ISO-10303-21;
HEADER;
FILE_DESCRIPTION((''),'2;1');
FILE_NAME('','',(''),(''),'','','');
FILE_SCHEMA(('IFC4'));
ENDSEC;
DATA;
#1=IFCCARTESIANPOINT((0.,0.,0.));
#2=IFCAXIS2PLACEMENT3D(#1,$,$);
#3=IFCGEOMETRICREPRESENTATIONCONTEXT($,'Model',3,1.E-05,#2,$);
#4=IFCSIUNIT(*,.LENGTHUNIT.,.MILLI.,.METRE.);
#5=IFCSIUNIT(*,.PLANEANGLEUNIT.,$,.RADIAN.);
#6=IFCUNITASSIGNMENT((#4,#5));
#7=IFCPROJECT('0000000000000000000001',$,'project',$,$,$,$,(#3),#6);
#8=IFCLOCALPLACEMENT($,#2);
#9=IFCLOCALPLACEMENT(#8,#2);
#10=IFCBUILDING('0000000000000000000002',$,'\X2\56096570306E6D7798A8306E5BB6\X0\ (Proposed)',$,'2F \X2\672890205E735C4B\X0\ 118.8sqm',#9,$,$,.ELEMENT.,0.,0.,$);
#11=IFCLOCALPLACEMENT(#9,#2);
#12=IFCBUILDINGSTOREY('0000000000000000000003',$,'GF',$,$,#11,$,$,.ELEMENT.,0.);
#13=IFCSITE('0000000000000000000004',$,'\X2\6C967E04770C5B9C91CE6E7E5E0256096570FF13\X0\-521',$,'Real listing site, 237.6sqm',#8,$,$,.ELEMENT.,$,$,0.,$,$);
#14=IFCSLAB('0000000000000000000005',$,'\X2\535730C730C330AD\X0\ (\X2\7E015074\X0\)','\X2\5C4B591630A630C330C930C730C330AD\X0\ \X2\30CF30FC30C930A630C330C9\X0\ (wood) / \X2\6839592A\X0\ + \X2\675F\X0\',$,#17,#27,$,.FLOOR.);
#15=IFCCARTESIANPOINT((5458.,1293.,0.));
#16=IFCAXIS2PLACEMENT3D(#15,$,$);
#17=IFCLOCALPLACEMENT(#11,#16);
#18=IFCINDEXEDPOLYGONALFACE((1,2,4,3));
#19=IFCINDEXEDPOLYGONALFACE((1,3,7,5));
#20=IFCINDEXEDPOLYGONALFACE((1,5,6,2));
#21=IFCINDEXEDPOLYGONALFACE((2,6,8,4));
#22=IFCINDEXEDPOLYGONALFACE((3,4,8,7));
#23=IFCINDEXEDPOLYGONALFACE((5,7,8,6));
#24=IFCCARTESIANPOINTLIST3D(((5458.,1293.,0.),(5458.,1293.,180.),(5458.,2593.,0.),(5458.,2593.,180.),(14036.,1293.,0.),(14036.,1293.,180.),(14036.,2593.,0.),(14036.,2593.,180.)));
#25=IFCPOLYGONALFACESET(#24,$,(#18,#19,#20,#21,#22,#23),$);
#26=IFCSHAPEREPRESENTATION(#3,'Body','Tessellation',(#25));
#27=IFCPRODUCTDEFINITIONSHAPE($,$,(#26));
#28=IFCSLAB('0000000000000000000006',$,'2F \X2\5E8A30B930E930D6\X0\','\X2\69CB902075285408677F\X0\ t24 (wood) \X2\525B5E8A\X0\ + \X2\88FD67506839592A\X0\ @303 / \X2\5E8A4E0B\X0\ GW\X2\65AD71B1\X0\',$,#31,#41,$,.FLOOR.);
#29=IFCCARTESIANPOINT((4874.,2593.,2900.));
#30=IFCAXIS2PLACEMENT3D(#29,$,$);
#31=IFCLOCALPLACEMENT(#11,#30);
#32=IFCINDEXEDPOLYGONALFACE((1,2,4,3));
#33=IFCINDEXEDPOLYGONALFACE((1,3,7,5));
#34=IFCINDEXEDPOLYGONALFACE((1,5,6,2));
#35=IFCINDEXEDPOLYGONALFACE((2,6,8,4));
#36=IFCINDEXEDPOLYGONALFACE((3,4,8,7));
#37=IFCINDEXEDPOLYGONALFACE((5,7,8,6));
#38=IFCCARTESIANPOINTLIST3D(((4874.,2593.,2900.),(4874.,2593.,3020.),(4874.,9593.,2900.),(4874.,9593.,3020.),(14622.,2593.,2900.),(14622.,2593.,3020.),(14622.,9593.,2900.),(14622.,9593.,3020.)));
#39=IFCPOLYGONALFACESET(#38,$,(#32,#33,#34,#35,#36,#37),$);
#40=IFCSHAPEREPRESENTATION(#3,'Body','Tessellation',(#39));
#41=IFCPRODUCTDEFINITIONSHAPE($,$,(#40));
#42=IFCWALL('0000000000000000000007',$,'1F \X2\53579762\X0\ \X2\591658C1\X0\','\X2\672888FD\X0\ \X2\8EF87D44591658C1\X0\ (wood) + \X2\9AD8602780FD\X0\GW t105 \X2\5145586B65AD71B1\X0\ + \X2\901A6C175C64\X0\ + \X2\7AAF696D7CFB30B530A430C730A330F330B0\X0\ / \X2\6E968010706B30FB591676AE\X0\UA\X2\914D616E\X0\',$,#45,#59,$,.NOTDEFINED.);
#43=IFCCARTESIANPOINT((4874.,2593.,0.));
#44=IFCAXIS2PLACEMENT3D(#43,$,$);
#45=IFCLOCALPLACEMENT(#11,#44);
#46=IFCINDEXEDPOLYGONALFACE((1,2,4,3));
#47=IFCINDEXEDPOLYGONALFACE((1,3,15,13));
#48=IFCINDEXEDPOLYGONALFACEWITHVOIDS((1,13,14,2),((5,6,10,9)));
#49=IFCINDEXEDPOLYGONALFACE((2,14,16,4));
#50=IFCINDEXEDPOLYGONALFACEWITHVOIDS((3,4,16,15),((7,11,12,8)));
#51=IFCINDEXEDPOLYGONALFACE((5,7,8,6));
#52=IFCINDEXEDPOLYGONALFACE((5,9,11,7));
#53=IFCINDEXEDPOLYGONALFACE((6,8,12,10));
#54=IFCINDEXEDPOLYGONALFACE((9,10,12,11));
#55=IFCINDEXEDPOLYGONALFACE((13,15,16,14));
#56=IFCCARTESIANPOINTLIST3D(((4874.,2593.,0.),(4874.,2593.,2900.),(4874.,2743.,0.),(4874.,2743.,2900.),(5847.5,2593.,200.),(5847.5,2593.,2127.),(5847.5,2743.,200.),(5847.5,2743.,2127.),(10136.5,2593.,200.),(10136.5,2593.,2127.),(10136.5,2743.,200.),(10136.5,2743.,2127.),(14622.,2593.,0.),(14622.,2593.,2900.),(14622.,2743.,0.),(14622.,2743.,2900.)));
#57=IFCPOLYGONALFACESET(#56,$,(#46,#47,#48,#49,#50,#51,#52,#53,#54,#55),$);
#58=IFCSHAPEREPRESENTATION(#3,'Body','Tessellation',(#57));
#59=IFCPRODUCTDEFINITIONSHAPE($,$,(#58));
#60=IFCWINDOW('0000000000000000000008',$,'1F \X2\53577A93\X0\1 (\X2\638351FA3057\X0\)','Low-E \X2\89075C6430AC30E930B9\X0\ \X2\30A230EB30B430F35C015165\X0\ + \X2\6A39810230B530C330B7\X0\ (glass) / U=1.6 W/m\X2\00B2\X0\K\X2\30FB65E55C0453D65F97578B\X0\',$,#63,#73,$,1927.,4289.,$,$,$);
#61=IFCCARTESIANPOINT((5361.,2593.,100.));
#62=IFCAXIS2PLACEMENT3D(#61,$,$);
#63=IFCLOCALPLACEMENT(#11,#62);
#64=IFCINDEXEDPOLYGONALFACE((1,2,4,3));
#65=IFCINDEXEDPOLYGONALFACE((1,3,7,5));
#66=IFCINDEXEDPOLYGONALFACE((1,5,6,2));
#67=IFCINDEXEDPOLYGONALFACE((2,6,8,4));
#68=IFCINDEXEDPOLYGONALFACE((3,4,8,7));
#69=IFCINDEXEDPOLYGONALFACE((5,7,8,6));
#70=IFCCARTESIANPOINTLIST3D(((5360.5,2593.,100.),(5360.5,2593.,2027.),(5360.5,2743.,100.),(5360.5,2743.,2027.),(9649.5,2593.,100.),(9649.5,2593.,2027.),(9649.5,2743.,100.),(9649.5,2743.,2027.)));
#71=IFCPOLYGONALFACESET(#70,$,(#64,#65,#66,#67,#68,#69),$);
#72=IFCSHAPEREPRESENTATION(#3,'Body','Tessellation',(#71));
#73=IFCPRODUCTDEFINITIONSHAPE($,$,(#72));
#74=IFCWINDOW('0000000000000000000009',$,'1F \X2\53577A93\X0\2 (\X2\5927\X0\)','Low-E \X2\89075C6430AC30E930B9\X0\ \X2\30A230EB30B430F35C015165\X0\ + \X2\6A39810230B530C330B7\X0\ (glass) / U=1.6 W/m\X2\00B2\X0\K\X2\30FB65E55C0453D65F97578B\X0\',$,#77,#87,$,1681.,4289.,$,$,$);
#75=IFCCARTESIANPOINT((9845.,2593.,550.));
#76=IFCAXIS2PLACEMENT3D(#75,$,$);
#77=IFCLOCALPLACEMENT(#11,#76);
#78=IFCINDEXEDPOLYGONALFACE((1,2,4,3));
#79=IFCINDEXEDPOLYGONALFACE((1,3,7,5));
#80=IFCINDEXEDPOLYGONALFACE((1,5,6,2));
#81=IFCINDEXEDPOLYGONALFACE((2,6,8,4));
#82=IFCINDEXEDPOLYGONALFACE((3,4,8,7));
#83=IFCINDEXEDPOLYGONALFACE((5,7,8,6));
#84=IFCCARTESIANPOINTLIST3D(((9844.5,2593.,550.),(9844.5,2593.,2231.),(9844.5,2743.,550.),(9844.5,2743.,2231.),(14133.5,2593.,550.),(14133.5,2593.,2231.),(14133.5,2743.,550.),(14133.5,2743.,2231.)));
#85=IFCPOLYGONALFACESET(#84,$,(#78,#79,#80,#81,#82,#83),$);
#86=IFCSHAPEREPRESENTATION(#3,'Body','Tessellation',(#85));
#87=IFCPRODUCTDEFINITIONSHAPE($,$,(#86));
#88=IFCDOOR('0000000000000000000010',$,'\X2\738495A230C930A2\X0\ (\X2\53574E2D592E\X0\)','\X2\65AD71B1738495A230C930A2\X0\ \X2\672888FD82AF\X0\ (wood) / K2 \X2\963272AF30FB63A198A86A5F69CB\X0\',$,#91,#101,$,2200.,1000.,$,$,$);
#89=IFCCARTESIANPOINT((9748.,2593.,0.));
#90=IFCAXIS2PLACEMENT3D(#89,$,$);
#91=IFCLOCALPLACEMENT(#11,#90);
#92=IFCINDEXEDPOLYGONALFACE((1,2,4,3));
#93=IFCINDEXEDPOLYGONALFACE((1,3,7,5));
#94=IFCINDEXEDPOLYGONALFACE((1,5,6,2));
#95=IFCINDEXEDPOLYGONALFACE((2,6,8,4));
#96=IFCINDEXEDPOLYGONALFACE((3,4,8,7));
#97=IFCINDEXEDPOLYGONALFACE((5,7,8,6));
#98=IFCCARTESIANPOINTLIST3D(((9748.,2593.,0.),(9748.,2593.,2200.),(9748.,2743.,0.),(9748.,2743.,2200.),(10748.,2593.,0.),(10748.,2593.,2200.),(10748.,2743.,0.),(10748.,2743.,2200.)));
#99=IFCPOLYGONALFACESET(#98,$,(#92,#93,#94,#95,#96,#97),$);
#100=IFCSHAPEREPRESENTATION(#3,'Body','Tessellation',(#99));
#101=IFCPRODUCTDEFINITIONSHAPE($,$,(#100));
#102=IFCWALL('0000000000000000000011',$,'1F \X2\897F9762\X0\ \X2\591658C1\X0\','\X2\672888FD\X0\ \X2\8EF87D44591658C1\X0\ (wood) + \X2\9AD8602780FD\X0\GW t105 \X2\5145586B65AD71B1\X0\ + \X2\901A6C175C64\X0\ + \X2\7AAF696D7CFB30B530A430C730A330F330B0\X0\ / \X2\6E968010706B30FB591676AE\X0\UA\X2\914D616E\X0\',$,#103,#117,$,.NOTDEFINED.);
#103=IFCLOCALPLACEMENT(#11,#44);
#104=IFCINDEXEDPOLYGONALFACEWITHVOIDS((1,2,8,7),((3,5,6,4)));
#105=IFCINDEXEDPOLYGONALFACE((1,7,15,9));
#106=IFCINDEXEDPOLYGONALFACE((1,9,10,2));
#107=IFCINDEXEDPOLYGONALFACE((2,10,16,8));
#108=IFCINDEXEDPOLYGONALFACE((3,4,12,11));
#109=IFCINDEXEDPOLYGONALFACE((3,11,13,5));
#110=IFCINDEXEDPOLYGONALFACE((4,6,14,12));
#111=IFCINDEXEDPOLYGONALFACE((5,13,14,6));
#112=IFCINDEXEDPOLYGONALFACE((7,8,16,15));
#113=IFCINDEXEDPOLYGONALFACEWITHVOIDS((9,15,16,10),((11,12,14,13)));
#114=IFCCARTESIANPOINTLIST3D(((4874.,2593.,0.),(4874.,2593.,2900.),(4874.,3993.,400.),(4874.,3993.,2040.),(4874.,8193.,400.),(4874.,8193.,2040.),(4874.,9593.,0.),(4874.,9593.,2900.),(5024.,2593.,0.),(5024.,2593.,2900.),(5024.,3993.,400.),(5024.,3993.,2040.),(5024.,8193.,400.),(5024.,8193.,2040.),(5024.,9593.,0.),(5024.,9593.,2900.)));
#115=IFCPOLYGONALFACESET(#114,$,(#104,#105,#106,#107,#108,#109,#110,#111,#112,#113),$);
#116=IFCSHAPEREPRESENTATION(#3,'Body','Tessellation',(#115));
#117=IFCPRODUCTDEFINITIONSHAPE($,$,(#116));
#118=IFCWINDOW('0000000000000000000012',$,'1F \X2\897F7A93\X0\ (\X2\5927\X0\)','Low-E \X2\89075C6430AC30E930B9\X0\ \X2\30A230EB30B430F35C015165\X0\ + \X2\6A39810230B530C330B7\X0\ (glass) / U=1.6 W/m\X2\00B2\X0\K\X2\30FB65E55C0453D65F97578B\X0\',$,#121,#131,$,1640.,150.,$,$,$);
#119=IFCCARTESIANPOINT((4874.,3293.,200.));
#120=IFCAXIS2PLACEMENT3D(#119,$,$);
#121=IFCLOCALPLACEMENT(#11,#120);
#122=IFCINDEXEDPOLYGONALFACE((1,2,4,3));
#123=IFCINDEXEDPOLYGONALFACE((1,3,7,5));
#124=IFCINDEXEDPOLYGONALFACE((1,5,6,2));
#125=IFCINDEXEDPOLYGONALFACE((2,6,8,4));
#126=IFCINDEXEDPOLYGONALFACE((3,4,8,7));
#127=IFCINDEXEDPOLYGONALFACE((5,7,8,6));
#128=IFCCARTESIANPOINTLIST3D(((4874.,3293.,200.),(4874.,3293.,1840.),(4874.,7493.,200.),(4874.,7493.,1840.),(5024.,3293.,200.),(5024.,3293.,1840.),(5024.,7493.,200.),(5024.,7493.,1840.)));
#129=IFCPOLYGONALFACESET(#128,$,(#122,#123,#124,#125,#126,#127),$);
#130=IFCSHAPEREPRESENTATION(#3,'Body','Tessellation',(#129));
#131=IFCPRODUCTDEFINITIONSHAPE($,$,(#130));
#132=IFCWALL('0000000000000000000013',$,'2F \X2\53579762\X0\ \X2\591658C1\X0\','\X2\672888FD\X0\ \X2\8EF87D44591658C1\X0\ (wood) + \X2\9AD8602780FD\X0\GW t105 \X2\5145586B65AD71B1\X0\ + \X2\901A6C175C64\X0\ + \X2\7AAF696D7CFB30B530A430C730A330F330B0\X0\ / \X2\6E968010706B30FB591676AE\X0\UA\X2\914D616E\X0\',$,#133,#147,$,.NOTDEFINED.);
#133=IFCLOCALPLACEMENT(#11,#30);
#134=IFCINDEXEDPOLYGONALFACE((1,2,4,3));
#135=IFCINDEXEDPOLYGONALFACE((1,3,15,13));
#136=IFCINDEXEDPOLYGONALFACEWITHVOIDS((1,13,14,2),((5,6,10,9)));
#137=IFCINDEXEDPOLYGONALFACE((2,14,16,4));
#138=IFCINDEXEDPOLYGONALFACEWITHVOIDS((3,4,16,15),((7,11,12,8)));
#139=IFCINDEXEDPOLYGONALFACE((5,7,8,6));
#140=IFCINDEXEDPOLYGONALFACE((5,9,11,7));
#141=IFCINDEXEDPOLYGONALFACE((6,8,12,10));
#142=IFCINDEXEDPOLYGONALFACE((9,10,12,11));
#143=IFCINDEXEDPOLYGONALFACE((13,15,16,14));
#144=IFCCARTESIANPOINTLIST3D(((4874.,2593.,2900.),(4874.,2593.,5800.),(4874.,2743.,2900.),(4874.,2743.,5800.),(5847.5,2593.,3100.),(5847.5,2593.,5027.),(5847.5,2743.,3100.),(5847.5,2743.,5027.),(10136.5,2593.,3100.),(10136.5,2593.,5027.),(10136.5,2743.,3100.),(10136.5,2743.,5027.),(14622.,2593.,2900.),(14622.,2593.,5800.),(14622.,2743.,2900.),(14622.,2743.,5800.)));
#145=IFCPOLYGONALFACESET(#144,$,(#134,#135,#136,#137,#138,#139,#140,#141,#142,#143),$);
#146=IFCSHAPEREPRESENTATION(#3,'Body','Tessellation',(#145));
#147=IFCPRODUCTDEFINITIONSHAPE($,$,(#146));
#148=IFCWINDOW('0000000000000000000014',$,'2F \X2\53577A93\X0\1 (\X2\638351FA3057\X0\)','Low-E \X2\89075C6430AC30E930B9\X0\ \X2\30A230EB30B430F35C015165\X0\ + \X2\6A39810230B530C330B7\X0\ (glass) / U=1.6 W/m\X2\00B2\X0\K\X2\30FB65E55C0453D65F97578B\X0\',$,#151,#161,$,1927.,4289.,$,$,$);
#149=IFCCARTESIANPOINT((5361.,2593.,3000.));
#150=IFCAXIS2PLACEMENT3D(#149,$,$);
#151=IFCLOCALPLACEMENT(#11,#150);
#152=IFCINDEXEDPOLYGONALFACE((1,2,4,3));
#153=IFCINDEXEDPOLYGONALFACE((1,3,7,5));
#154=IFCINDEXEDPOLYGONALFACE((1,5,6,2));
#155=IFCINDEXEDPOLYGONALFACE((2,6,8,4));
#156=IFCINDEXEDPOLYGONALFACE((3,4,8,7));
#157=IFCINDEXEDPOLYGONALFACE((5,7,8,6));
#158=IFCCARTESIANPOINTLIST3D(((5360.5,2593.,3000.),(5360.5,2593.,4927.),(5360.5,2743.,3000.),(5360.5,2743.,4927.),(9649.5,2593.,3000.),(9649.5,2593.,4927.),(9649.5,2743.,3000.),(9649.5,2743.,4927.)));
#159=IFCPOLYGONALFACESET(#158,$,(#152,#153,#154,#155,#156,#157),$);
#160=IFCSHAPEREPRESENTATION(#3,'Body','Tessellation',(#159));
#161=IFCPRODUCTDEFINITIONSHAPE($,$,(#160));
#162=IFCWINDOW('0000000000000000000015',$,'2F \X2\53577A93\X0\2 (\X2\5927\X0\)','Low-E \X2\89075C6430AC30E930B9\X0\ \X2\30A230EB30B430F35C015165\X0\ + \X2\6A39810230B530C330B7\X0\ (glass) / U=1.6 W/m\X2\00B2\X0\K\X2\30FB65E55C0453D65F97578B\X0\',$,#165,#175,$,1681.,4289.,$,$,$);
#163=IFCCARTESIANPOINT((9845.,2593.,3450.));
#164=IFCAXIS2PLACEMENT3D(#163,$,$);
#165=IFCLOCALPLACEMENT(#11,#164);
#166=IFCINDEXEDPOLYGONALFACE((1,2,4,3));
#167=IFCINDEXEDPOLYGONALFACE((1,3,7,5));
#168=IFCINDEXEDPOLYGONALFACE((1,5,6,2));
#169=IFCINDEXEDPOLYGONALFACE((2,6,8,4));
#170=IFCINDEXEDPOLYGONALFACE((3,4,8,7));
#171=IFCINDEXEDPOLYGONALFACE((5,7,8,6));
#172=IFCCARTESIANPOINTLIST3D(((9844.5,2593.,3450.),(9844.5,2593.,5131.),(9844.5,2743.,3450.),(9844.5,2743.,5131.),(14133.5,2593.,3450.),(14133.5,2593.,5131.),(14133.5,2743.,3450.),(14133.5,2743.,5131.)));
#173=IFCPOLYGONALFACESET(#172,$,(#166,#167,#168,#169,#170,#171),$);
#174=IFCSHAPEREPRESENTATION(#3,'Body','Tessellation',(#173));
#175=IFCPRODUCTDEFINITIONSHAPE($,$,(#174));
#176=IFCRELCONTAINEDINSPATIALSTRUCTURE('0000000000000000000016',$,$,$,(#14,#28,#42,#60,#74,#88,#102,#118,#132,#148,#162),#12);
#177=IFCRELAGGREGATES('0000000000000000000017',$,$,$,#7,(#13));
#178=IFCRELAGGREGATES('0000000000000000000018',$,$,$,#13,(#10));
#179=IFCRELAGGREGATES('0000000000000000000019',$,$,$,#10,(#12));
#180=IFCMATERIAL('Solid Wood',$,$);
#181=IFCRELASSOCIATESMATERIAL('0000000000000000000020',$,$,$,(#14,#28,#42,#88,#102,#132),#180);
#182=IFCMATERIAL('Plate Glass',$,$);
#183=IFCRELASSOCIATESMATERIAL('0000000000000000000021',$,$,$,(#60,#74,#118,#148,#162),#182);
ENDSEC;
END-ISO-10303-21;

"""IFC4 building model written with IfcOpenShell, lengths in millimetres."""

from ifc_helpers import new_model, si_unit, frame, frame_2d, origin, place, context, project, spatial, rectangle, extrude, material, element, fill, save


model = new_model("IFC4")

# Units and contexts
model_context = context("Model", 3, precision=1e-05, world=origin())
ifc_project = project(units=[si_unit("LENGTHUNIT", "METRE", prefix="MILLI"), si_unit("PLANEANGLEUNIT", "RADIAN")], contexts=[model_context])

# Site, building, storey
site_placement = place(None, origin())
site = spatial("IfcSite", under=ifc_project, at=site_placement, Name="沖縄県宜野湾市嘉数３-521", ObjectType="Real listing site, 237.6sqm", CompositionType="ELEMENT", RefElevation=0.0)
building_placement = place(site_placement, origin())
building = spatial("IfcBuilding", under=site, at=building_placement, Name="嘉数の海風の家 (Proposed)", ObjectType="2F 木造平屋 118.8sqm", CompositionType="ELEMENT", ElevationOfRefHeight=0.0, ElevationOfTerrain=0.0)
storey_placement = place(building_placement, origin())
storey = spatial("IfcBuildingStorey", under=building, at=storey_placement, Name="GF", CompositionType="ELEMENT", Elevation=0.0)

# Slabs
ifc_material_1 = material(Name="Solid Wood")
slab_1_placement = place(storey_placement, frame((5458.0, 1293.0, 0.0)))
element("IfcSlab", 1, at=slab_1_placement, inside=storey, material=ifc_material_1, Name="南デッキ (縁側)", Description="屋外ウッドデッキ ハードウッド (wood) / 根太 + 束", PredefinedType="FLOOR", context=model_context, shape_type="SweptSolid", body=[
    extrude(rectangle(XDim=8578.0, YDim=1300.0, at=frame_2d((4289.0, 650.0))), frame((5458.0, 1293.0, 0.0)), (0.0, 0.0, 1.0), 180.0),
])
slab_2_placement = place(storey_placement, frame((4874.0, 2593.0, 2900.0)))
element("IfcSlab", 2, at=slab_2_placement, inside=storey, material=ifc_material_1, Name="2F 床スラブ", Description="構造用合板 t24 (wood) 剛床 + 製材根太 @303 / 床下 GW断熱", PredefinedType="FLOOR", context=model_context, shape_type="SweptSolid", body=[
    extrude(rectangle(XDim=9748.0, YDim=7000.0, at=frame_2d((4874.0, 3500.0))), frame((4874.0, 2593.0, 2900.0)), (0.0, 0.0, 1.0), 120.0),
])

# Wall, openings, windows, door
wall_1_placement = place(storey_placement, frame((4874.0, 2593.0, 0.0)))
wall_1 = element("IfcWall", 3, at=wall_1_placement, inside=storey, material=ifc_material_1, Name="1F 南面 外壁", Description="木製 軸組外壁 (wood) + 高性能GW t105 充填断熱 + 通気層 + 窯業系サイディング / 準耐火・外皮UA配慮", PredefinedType="NOTDEFINED", context=model_context, shape_type="SweptSolid", body=[
    extrude(rectangle(XDim=9748.0, YDim=150.0, at=frame_2d((4874.0, 75.0))), frame((4874.0, 2593.0, 0.0)), (0.0, 0.0, 1.0), 2900.0),
])
opening_1_placement = place(storey_placement, frame((5361.0, 2593.0, 100.0)))
opening_1 = element("IfcOpeningElement", 4, at=opening_1_placement, cuts=wall_1, PredefinedType="NOTDEFINED", context=model_context, shape_type="SweptSolid", body=[
    extrude(rectangle(XDim=4289.0, YDim=150.0, at=frame_2d((2144.0, 75.0))), frame((5361.0, 2593.0, 100.0)), (0.0, 0.0, 1.0), 1927.0),
])
opening_2_placement = place(storey_placement, frame((9845.0, 2593.0, 550.0)))
opening_2 = element("IfcOpeningElement", 5, at=opening_2_placement, cuts=wall_1, PredefinedType="NOTDEFINED", context=model_context, shape_type="SweptSolid", body=[
    extrude(rectangle(XDim=4289.0, YDim=150.0, at=frame_2d((2144.0, 75.0))), frame((9845.0, 2593.0, 550.0)), (0.0, 0.0, 1.0), 1681.0),
])
opening_3_placement = place(storey_placement, frame((9748.0, 2593.0, 0.0)))
opening_3 = element("IfcOpeningElement", 6, at=opening_3_placement, cuts=wall_1, PredefinedType="NOTDEFINED", context=model_context, shape_type="SweptSolid", body=[
    extrude(rectangle(XDim=1000.0, YDim=150.0, at=frame_2d((500.0, 75.0))), frame((9748.0, 2593.0, 0.0)), (0.0, 0.0, 1.0), 2200.0),
])
ifc_material_2 = material(Name="Plate Glass")
window_1_placement = place(storey_placement, frame((5361.0, 2593.0, 100.0)))
window_1 = element("IfcWindow", 7, at=window_1_placement, inside=storey, material=ifc_material_2, Name="1F 南窓1 (掃出し)", Description="Low-E 複層ガラス アルゴン封入 + 樹脂サッシ (glass) / U=1.6 W/m²K・日射取得型", OverallHeight=1927.0, OverallWidth=4289.0, context=model_context, shape_type="SweptSolid", body=[
    extrude(rectangle(XDim=4289.0, YDim=150.0, at=frame_2d((2144.0, 75.0))), frame((5361.0, 2593.0, 100.0)), (0.0, 0.0, 1.0), 1927.0),
])
fill(opening_1, window_1)
window_2_placement = place(storey_placement, frame((9845.0, 2593.0, 550.0)))
window_2 = element("IfcWindow", 8, at=window_2_placement, inside=storey, material=ifc_material_2, Name="1F 南窓2 (大)", Description="Low-E 複層ガラス アルゴン封入 + 樹脂サッシ (glass) / U=1.6 W/m²K・日射取得型", OverallHeight=1681.0, OverallWidth=4289.0, context=model_context, shape_type="SweptSolid", body=[
    extrude(rectangle(XDim=4289.0, YDim=150.0, at=frame_2d((2144.0, 75.0))), frame((9845.0, 2593.0, 550.0)), (0.0, 0.0, 1.0), 1681.0),
])
fill(opening_2, window_2)
door_placement = place(storey_placement, frame((9748.0, 2593.0, 0.0)))
door = element("IfcDoor", 9, at=door_placement, inside=storey, material=ifc_material_1, Name="玄関ドア (南中央)", Description="断熱玄関ドア 木製芯 (wood) / K2 防犯・採風機構", OverallHeight=2200.0, OverallWidth=1000.0, context=model_context, shape_type="SweptSolid", body=[
    extrude(rectangle(XDim=1000.0, YDim=150.0, at=frame_2d((500.0, 75.0))), frame((9748.0, 2593.0, 0.0)), (0.0, 0.0, 1.0), 2200.0),
])
fill(opening_3, door)

# Wall, opening, window
wall_2_placement = place(storey_placement, frame((4874.0, 2593.0, 0.0)))
wall_2 = element("IfcWall", 10, at=wall_2_placement, inside=storey, material=ifc_material_1, Name="1F 西面 外壁", Description="木製 軸組外壁 (wood) + 高性能GW t105 充填断熱 + 通気層 + 窯業系サイディング / 準耐火・外皮UA配慮", PredefinedType="NOTDEFINED", context=model_context, shape_type="SweptSolid", body=[
    extrude(rectangle(XDim=150.0, YDim=7000.0, at=frame_2d((75.0, 3500.0))), frame((4874.0, 2593.0, 0.0)), (0.0, 0.0, 1.0), 2900.0),
])
opening_4_placement = place(storey_placement, frame((4874.0, 3293.0, 200.0)))
opening_4 = element("IfcOpeningElement", 11, at=opening_4_placement, cuts=wall_2, PredefinedType="NOTDEFINED", context=model_context, shape_type="SweptSolid", body=[
    extrude(rectangle(XDim=150.0, YDim=4200.0, at=frame_2d((75.0, 2100.0))), frame((4874.0, 3293.0, 200.0)), (0.0, 0.0, 1.0), 1640.0),
])
window_3_placement = place(storey_placement, frame((4874.0, 3293.0, 200.0)))
window_3 = element("IfcWindow", 12, at=window_3_placement, inside=storey, material=ifc_material_2, Name="1F 西窓 (大)", Description="Low-E 複層ガラス アルゴン封入 + 樹脂サッシ (glass) / U=1.6 W/m²K・日射取得型", OverallHeight=1640.0, OverallWidth=150.0, context=model_context, shape_type="SweptSolid", body=[
    extrude(rectangle(XDim=150.0, YDim=4200.0, at=frame_2d((75.0, 2100.0))), frame((4874.0, 3293.0, 200.0)), (0.0, 0.0, 1.0), 1640.0),
])
fill(opening_4, window_3)

# Wall, openings, windows
wall_3_placement = place(storey_placement, frame((4874.0, 2593.0, 2900.0)))
wall_3 = element("IfcWall", 13, at=wall_3_placement, inside=storey, material=ifc_material_1, Name="2F 南面 外壁", Description="木製 軸組外壁 (wood) + 高性能GW t105 充填断熱 + 通気層 + 窯業系サイディング / 準耐火・外皮UA配慮", PredefinedType="NOTDEFINED", context=model_context, shape_type="SweptSolid", body=[
    extrude(rectangle(XDim=9748.0, YDim=150.0, at=frame_2d((4874.0, 75.0))), frame((4874.0, 2593.0, 2900.0)), (0.0, 0.0, 1.0), 2900.0),
])
opening_5_placement = place(storey_placement, frame((5361.0, 2593.0, 3000.0)))
opening_5 = element("IfcOpeningElement", 14, at=opening_5_placement, cuts=wall_3, PredefinedType="NOTDEFINED", context=model_context, shape_type="SweptSolid", body=[
    extrude(rectangle(XDim=4289.0, YDim=150.0, at=frame_2d((2144.0, 75.0))), frame((5361.0, 2593.0, 3000.0)), (0.0, 0.0, 1.0), 1927.0),
])
opening_6_placement = place(storey_placement, frame((9845.0, 2593.0, 3450.0)))
opening_6 = element("IfcOpeningElement", 15, at=opening_6_placement, cuts=wall_3, PredefinedType="NOTDEFINED", context=model_context, shape_type="SweptSolid", body=[
    extrude(rectangle(XDim=4289.0, YDim=150.0, at=frame_2d((2144.0, 75.0))), frame((9845.0, 2593.0, 3450.0)), (0.0, 0.0, 1.0), 1681.0),
])
window_4_placement = place(storey_placement, frame((5361.0, 2593.0, 3000.0)))
window_4 = element("IfcWindow", 16, at=window_4_placement, inside=storey, material=ifc_material_2, Name="2F 南窓1 (掃出し)", Description="Low-E 複層ガラス アルゴン封入 + 樹脂サッシ (glass) / U=1.6 W/m²K・日射取得型", OverallHeight=1927.0, OverallWidth=4289.0, context=model_context, shape_type="SweptSolid", body=[
    extrude(rectangle(XDim=4289.0, YDim=150.0, at=frame_2d((2144.0, 75.0))), frame((5361.0, 2593.0, 3000.0)), (0.0, 0.0, 1.0), 1927.0),
])
fill(opening_5, window_4)
window_5_placement = place(storey_placement, frame((9845.0, 2593.0, 3450.0)))
window_5 = element("IfcWindow", 17, at=window_5_placement, inside=storey, material=ifc_material_2, Name="2F 南窓2 (大)", Description="Low-E 複層ガラス アルゴン封入 + 樹脂サッシ (glass) / U=1.6 W/m²K・日射取得型", OverallHeight=1681.0, OverallWidth=4289.0, context=model_context, shape_type="SweptSolid", body=[
    extrude(rectangle(XDim=4289.0, YDim=150.0, at=frame_2d((2144.0, 75.0))), frame((9845.0, 2593.0, 3450.0)), (0.0, 0.0, 1.0), 1681.0),
])
fill(opening_6, window_5)

save(model, "model.ifc")
